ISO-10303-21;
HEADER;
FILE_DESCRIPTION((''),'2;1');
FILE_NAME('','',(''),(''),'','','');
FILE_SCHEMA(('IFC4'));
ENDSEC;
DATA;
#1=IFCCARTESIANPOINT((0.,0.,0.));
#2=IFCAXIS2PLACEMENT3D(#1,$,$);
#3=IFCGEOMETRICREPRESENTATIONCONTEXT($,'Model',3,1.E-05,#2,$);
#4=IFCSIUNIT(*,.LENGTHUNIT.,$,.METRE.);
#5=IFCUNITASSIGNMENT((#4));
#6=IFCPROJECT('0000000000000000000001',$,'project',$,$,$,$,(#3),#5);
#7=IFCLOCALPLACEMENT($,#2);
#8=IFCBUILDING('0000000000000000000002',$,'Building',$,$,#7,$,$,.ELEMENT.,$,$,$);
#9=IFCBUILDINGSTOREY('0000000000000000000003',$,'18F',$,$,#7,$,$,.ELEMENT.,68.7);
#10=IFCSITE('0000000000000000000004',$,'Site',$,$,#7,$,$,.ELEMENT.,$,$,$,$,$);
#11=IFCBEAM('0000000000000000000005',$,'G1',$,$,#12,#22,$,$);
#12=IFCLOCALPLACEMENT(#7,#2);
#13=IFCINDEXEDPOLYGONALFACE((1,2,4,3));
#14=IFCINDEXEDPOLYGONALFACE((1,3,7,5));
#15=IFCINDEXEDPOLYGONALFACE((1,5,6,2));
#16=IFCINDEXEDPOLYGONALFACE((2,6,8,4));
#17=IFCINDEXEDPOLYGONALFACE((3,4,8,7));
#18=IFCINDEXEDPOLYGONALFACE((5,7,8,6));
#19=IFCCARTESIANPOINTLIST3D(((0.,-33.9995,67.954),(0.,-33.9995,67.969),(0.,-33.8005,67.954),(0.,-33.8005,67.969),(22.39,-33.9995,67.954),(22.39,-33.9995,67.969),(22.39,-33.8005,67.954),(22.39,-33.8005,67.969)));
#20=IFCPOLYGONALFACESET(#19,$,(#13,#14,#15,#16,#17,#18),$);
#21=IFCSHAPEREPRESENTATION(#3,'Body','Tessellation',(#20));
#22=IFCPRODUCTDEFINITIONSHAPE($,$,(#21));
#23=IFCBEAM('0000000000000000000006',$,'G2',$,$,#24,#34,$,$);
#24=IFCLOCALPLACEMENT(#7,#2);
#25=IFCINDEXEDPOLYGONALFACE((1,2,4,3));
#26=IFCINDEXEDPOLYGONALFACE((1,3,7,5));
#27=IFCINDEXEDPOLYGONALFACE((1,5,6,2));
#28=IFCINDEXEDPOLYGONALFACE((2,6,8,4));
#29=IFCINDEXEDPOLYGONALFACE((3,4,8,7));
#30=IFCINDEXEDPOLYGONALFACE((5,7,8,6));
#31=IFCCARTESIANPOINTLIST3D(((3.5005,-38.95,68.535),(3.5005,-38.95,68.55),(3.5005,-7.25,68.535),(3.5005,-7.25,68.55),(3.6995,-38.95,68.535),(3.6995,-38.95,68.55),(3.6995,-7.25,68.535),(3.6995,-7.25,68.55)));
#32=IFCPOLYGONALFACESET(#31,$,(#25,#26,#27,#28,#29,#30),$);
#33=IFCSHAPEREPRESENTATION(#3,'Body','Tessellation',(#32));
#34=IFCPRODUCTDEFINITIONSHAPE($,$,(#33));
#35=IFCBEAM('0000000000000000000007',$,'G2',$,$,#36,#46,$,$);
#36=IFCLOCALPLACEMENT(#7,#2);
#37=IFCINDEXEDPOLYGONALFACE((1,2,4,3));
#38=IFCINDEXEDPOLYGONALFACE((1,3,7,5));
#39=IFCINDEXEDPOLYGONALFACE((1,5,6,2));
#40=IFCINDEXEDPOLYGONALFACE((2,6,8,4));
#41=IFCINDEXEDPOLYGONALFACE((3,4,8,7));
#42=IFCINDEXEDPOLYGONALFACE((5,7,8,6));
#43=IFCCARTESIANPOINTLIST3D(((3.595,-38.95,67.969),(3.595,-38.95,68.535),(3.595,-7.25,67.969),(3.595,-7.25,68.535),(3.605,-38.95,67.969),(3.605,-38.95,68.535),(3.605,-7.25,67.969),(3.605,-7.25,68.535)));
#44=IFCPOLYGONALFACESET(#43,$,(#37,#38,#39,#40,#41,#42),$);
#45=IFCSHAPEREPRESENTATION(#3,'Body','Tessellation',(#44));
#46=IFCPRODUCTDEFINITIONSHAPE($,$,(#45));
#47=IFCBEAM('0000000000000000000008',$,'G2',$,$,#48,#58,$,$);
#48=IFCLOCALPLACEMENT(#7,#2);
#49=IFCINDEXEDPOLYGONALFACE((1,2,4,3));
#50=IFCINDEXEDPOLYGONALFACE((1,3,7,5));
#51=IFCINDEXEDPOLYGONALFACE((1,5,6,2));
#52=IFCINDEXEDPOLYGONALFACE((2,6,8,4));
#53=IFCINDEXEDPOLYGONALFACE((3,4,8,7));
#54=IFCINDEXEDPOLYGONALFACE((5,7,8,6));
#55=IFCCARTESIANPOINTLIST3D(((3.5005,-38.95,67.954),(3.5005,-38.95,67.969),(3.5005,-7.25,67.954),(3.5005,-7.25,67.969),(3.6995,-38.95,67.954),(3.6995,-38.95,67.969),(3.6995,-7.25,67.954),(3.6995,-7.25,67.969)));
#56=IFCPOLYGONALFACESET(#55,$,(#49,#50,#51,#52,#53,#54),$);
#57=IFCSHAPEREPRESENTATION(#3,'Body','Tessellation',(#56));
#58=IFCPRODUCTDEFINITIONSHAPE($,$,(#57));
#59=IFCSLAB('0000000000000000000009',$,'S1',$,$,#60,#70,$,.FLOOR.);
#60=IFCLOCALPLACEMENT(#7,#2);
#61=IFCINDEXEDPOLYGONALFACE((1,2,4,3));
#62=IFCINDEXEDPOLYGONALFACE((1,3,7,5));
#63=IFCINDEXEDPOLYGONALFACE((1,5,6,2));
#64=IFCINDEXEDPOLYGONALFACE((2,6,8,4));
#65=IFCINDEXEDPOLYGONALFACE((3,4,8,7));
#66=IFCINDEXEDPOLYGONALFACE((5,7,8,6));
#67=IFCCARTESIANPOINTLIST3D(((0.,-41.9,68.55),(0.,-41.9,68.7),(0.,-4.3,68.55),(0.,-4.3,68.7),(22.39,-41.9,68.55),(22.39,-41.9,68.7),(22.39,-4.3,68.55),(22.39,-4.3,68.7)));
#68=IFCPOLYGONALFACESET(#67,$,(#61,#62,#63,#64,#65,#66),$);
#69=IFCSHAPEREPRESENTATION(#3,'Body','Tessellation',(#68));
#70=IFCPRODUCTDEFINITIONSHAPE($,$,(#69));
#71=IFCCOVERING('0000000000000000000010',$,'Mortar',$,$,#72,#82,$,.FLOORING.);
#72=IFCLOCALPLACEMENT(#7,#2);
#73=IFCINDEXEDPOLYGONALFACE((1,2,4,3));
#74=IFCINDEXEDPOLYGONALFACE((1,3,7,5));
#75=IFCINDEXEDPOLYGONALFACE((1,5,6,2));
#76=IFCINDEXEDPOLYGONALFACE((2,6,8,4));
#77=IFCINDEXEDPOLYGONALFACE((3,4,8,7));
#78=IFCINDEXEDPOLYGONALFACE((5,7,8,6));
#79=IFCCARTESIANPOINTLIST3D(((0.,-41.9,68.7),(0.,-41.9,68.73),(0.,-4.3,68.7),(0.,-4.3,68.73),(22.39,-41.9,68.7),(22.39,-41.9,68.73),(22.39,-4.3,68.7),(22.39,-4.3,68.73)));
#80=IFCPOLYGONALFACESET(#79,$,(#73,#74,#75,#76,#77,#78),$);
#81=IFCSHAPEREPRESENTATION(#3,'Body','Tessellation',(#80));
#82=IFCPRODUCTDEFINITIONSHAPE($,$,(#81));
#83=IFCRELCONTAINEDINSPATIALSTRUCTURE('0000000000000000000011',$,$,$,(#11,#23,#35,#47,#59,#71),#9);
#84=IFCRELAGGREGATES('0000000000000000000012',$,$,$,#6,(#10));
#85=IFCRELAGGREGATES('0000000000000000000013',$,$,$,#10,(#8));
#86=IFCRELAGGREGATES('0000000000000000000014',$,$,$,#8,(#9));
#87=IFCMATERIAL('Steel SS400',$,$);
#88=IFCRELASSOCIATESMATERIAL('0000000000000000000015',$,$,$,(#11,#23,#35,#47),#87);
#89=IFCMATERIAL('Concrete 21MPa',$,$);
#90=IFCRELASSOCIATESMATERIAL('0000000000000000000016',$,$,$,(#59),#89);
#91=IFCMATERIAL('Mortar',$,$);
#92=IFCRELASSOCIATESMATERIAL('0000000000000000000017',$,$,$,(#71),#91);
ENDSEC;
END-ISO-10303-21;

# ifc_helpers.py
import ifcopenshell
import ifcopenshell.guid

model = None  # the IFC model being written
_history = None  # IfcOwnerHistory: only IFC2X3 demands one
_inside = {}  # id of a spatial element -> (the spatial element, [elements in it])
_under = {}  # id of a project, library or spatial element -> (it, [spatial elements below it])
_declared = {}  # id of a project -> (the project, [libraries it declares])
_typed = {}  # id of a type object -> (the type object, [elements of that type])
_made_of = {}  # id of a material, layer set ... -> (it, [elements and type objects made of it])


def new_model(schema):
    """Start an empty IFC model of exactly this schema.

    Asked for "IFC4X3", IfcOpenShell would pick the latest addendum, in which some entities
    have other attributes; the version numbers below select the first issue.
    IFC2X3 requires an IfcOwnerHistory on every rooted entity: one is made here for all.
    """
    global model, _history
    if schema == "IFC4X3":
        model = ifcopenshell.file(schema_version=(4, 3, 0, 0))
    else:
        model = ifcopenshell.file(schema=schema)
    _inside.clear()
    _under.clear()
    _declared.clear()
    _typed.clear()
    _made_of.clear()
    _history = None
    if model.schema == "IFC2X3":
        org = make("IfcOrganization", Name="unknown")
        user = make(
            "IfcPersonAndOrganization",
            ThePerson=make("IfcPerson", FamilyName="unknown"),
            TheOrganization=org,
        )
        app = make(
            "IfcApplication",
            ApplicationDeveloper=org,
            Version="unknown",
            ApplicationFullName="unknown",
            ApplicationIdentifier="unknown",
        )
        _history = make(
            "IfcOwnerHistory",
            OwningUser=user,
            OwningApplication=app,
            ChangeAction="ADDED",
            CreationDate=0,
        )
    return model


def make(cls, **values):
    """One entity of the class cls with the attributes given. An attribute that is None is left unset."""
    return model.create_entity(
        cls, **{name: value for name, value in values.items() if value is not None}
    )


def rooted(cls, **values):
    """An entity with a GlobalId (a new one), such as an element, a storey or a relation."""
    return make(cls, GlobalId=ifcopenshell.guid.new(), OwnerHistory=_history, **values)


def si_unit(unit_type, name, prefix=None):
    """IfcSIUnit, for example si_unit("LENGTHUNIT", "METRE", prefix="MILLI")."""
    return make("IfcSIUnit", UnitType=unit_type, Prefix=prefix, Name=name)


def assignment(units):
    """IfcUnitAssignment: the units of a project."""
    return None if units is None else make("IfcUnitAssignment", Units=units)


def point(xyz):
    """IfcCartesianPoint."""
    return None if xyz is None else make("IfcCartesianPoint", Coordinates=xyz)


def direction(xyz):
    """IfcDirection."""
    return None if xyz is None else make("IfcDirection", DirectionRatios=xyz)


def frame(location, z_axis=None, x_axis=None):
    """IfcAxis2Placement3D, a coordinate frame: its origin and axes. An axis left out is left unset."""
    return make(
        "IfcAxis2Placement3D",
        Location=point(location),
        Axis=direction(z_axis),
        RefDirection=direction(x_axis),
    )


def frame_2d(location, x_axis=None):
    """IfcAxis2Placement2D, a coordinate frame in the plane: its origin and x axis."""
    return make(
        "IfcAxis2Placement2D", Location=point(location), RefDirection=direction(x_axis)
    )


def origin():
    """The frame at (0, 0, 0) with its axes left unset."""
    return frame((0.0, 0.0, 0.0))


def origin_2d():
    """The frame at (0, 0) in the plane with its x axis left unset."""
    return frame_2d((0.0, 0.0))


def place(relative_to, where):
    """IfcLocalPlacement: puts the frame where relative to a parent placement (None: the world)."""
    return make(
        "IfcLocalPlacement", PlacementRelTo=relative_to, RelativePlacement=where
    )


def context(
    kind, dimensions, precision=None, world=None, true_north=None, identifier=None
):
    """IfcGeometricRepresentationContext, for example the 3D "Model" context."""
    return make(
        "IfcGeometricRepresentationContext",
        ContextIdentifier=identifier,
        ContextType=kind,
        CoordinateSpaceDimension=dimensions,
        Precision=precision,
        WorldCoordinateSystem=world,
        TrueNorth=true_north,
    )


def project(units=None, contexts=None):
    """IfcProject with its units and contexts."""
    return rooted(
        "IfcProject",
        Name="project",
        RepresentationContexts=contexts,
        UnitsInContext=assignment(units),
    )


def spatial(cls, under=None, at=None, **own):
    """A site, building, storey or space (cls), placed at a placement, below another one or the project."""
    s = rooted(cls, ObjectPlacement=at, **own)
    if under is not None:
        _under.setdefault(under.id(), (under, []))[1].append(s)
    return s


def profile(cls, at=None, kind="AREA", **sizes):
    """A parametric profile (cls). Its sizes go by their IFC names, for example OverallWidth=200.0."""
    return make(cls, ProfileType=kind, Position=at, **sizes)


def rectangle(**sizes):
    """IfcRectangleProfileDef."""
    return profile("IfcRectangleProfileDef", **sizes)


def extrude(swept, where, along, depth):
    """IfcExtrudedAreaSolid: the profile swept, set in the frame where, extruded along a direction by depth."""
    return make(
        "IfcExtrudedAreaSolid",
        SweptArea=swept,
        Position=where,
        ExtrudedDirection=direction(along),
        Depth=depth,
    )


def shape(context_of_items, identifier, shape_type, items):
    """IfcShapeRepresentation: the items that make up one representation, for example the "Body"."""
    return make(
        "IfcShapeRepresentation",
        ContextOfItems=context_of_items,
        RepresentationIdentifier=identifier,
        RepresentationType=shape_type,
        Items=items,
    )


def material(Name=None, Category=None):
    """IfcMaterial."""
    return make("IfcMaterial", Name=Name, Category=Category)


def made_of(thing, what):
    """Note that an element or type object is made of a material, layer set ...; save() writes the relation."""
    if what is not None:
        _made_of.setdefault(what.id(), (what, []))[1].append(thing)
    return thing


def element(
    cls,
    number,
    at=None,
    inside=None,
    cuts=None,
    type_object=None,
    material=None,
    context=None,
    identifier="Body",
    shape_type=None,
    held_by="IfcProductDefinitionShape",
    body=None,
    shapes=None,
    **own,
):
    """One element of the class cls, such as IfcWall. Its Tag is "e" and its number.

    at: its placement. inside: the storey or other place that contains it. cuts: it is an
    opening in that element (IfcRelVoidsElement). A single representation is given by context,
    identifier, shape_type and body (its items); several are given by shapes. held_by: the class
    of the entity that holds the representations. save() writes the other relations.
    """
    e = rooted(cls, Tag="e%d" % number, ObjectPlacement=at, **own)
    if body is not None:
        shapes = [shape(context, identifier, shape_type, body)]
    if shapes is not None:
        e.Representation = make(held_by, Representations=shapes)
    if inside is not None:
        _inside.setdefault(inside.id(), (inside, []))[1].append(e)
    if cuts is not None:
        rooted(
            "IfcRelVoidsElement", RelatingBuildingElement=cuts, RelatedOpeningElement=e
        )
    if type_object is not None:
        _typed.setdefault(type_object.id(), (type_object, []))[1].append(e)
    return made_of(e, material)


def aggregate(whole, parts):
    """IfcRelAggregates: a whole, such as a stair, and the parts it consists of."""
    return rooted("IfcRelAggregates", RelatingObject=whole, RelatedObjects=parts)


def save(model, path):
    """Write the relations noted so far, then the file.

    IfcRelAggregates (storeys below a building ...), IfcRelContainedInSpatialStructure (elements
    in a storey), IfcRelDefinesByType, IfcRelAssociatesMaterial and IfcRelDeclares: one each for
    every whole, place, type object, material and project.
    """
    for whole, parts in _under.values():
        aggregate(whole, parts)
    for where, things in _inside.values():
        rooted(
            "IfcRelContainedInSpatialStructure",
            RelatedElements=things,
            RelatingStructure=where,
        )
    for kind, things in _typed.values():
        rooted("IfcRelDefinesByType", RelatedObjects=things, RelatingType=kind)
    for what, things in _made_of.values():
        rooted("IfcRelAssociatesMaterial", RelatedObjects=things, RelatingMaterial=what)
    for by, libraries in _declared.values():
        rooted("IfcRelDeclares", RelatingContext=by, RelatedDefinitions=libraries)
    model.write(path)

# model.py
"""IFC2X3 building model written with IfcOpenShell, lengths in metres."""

from ifc_helpers import new_model, si_unit, frame, origin, origin_2d, place, context, project, spatial, rectangle, extrude, material, element, save


model = new_model("IFC2X3")

# Units and contexts
model_context = context("Model", 3, precision=1e-05, world=origin())
ifc_project = project(units=[si_unit("LENGTHUNIT", "METRE")], contexts=[model_context])

# Site, building, storey
placement = place(None, origin())
site = spatial("IfcSite", under=ifc_project, at=placement, Name="Site", CompositionType="ELEMENT")
building = spatial("IfcBuilding", under=site, at=placement, Name="Building", CompositionType="ELEMENT")
storey = spatial("IfcBuildingStorey", under=building, at=placement, Name="18F", CompositionType="ELEMENT", Elevation=68.7)

# Shared definitions
ifc_material_1 = material(Name="Concrete 21MPa")
ifc_material_2 = material(Name="Steel SS400")

# Beams
beam_1_placement = place(None, frame((11.195, -33.9, 67.954)))
element("IfcBeam", 1, at=beam_1_placement, inside=storey, material=ifc_material_2, Name="G1", context=model_context, shape_type="SweptSolid", body=[
    extrude(rectangle(XDim=22.39, YDim=0.199, at=origin_2d()), origin(), (0.0, 0.0, 1.0), 0.015),
])
beam_2_placement = place(None, frame((3.6, -23.1, 68.535)))
element("IfcBeam", 2, at=beam_2_placement, inside=storey, material=ifc_material_2, Name="G2", context=model_context, shape_type="SweptSolid", body=[
    extrude(rectangle(XDim=0.199, YDim=31.7, at=origin_2d()), origin(), (0.0, 0.0, 1.0), 0.015),
])
beam_3_placement = place(None, frame((3.6, -23.1, 67.969)))
element("IfcBeam", 3, at=beam_3_placement, inside=storey, material=ifc_material_2, Name="G2", context=model_context, shape_type="SweptSolid", body=[
    extrude(rectangle(XDim=0.01, YDim=31.7, at=origin_2d()), origin(), (0.0, 0.0, 1.0), 0.566),
])
beam_4_placement = place(None, frame((3.6, -23.1, 67.954)))
element("IfcBeam", 4, at=beam_4_placement, inside=storey, material=ifc_material_2, Name="G2", context=model_context, shape_type="SweptSolid", body=[
    extrude(rectangle(XDim=0.199, YDim=31.7, at=origin_2d()), origin(), (0.0, 0.0, 1.0), 0.015),
])

# Slab
slab_placement = place(None, frame((11.195, -23.1, 68.55)))
element("IfcSlab", 5, at=slab_placement, inside=storey, material=ifc_material_1, Name="S1", PredefinedType="FLOOR", context=model_context, shape_type="SweptSolid", body=[
    extrude(rectangle(XDim=22.39, YDim=37.6, at=origin_2d()), origin(), (0.0, 0.0, 1.0), 0.15),
])

# Covering
ifc_material_3 = material(Name="Mortar")
covering_placement = place(None, frame((11.195, -23.1, 68.7)))
element("IfcCovering", 6, at=covering_placement, inside=storey, material=ifc_material_3, Name="Mortar", PredefinedType="FLOORING", context=model_context, shape_type="SweptSolid", body=[
    extrude(rectangle(XDim=22.39, YDim=37.6, at=origin_2d()), origin(), (0.0, 0.0, 1.0), 0.03),
])

save(model, "model.ifc")
